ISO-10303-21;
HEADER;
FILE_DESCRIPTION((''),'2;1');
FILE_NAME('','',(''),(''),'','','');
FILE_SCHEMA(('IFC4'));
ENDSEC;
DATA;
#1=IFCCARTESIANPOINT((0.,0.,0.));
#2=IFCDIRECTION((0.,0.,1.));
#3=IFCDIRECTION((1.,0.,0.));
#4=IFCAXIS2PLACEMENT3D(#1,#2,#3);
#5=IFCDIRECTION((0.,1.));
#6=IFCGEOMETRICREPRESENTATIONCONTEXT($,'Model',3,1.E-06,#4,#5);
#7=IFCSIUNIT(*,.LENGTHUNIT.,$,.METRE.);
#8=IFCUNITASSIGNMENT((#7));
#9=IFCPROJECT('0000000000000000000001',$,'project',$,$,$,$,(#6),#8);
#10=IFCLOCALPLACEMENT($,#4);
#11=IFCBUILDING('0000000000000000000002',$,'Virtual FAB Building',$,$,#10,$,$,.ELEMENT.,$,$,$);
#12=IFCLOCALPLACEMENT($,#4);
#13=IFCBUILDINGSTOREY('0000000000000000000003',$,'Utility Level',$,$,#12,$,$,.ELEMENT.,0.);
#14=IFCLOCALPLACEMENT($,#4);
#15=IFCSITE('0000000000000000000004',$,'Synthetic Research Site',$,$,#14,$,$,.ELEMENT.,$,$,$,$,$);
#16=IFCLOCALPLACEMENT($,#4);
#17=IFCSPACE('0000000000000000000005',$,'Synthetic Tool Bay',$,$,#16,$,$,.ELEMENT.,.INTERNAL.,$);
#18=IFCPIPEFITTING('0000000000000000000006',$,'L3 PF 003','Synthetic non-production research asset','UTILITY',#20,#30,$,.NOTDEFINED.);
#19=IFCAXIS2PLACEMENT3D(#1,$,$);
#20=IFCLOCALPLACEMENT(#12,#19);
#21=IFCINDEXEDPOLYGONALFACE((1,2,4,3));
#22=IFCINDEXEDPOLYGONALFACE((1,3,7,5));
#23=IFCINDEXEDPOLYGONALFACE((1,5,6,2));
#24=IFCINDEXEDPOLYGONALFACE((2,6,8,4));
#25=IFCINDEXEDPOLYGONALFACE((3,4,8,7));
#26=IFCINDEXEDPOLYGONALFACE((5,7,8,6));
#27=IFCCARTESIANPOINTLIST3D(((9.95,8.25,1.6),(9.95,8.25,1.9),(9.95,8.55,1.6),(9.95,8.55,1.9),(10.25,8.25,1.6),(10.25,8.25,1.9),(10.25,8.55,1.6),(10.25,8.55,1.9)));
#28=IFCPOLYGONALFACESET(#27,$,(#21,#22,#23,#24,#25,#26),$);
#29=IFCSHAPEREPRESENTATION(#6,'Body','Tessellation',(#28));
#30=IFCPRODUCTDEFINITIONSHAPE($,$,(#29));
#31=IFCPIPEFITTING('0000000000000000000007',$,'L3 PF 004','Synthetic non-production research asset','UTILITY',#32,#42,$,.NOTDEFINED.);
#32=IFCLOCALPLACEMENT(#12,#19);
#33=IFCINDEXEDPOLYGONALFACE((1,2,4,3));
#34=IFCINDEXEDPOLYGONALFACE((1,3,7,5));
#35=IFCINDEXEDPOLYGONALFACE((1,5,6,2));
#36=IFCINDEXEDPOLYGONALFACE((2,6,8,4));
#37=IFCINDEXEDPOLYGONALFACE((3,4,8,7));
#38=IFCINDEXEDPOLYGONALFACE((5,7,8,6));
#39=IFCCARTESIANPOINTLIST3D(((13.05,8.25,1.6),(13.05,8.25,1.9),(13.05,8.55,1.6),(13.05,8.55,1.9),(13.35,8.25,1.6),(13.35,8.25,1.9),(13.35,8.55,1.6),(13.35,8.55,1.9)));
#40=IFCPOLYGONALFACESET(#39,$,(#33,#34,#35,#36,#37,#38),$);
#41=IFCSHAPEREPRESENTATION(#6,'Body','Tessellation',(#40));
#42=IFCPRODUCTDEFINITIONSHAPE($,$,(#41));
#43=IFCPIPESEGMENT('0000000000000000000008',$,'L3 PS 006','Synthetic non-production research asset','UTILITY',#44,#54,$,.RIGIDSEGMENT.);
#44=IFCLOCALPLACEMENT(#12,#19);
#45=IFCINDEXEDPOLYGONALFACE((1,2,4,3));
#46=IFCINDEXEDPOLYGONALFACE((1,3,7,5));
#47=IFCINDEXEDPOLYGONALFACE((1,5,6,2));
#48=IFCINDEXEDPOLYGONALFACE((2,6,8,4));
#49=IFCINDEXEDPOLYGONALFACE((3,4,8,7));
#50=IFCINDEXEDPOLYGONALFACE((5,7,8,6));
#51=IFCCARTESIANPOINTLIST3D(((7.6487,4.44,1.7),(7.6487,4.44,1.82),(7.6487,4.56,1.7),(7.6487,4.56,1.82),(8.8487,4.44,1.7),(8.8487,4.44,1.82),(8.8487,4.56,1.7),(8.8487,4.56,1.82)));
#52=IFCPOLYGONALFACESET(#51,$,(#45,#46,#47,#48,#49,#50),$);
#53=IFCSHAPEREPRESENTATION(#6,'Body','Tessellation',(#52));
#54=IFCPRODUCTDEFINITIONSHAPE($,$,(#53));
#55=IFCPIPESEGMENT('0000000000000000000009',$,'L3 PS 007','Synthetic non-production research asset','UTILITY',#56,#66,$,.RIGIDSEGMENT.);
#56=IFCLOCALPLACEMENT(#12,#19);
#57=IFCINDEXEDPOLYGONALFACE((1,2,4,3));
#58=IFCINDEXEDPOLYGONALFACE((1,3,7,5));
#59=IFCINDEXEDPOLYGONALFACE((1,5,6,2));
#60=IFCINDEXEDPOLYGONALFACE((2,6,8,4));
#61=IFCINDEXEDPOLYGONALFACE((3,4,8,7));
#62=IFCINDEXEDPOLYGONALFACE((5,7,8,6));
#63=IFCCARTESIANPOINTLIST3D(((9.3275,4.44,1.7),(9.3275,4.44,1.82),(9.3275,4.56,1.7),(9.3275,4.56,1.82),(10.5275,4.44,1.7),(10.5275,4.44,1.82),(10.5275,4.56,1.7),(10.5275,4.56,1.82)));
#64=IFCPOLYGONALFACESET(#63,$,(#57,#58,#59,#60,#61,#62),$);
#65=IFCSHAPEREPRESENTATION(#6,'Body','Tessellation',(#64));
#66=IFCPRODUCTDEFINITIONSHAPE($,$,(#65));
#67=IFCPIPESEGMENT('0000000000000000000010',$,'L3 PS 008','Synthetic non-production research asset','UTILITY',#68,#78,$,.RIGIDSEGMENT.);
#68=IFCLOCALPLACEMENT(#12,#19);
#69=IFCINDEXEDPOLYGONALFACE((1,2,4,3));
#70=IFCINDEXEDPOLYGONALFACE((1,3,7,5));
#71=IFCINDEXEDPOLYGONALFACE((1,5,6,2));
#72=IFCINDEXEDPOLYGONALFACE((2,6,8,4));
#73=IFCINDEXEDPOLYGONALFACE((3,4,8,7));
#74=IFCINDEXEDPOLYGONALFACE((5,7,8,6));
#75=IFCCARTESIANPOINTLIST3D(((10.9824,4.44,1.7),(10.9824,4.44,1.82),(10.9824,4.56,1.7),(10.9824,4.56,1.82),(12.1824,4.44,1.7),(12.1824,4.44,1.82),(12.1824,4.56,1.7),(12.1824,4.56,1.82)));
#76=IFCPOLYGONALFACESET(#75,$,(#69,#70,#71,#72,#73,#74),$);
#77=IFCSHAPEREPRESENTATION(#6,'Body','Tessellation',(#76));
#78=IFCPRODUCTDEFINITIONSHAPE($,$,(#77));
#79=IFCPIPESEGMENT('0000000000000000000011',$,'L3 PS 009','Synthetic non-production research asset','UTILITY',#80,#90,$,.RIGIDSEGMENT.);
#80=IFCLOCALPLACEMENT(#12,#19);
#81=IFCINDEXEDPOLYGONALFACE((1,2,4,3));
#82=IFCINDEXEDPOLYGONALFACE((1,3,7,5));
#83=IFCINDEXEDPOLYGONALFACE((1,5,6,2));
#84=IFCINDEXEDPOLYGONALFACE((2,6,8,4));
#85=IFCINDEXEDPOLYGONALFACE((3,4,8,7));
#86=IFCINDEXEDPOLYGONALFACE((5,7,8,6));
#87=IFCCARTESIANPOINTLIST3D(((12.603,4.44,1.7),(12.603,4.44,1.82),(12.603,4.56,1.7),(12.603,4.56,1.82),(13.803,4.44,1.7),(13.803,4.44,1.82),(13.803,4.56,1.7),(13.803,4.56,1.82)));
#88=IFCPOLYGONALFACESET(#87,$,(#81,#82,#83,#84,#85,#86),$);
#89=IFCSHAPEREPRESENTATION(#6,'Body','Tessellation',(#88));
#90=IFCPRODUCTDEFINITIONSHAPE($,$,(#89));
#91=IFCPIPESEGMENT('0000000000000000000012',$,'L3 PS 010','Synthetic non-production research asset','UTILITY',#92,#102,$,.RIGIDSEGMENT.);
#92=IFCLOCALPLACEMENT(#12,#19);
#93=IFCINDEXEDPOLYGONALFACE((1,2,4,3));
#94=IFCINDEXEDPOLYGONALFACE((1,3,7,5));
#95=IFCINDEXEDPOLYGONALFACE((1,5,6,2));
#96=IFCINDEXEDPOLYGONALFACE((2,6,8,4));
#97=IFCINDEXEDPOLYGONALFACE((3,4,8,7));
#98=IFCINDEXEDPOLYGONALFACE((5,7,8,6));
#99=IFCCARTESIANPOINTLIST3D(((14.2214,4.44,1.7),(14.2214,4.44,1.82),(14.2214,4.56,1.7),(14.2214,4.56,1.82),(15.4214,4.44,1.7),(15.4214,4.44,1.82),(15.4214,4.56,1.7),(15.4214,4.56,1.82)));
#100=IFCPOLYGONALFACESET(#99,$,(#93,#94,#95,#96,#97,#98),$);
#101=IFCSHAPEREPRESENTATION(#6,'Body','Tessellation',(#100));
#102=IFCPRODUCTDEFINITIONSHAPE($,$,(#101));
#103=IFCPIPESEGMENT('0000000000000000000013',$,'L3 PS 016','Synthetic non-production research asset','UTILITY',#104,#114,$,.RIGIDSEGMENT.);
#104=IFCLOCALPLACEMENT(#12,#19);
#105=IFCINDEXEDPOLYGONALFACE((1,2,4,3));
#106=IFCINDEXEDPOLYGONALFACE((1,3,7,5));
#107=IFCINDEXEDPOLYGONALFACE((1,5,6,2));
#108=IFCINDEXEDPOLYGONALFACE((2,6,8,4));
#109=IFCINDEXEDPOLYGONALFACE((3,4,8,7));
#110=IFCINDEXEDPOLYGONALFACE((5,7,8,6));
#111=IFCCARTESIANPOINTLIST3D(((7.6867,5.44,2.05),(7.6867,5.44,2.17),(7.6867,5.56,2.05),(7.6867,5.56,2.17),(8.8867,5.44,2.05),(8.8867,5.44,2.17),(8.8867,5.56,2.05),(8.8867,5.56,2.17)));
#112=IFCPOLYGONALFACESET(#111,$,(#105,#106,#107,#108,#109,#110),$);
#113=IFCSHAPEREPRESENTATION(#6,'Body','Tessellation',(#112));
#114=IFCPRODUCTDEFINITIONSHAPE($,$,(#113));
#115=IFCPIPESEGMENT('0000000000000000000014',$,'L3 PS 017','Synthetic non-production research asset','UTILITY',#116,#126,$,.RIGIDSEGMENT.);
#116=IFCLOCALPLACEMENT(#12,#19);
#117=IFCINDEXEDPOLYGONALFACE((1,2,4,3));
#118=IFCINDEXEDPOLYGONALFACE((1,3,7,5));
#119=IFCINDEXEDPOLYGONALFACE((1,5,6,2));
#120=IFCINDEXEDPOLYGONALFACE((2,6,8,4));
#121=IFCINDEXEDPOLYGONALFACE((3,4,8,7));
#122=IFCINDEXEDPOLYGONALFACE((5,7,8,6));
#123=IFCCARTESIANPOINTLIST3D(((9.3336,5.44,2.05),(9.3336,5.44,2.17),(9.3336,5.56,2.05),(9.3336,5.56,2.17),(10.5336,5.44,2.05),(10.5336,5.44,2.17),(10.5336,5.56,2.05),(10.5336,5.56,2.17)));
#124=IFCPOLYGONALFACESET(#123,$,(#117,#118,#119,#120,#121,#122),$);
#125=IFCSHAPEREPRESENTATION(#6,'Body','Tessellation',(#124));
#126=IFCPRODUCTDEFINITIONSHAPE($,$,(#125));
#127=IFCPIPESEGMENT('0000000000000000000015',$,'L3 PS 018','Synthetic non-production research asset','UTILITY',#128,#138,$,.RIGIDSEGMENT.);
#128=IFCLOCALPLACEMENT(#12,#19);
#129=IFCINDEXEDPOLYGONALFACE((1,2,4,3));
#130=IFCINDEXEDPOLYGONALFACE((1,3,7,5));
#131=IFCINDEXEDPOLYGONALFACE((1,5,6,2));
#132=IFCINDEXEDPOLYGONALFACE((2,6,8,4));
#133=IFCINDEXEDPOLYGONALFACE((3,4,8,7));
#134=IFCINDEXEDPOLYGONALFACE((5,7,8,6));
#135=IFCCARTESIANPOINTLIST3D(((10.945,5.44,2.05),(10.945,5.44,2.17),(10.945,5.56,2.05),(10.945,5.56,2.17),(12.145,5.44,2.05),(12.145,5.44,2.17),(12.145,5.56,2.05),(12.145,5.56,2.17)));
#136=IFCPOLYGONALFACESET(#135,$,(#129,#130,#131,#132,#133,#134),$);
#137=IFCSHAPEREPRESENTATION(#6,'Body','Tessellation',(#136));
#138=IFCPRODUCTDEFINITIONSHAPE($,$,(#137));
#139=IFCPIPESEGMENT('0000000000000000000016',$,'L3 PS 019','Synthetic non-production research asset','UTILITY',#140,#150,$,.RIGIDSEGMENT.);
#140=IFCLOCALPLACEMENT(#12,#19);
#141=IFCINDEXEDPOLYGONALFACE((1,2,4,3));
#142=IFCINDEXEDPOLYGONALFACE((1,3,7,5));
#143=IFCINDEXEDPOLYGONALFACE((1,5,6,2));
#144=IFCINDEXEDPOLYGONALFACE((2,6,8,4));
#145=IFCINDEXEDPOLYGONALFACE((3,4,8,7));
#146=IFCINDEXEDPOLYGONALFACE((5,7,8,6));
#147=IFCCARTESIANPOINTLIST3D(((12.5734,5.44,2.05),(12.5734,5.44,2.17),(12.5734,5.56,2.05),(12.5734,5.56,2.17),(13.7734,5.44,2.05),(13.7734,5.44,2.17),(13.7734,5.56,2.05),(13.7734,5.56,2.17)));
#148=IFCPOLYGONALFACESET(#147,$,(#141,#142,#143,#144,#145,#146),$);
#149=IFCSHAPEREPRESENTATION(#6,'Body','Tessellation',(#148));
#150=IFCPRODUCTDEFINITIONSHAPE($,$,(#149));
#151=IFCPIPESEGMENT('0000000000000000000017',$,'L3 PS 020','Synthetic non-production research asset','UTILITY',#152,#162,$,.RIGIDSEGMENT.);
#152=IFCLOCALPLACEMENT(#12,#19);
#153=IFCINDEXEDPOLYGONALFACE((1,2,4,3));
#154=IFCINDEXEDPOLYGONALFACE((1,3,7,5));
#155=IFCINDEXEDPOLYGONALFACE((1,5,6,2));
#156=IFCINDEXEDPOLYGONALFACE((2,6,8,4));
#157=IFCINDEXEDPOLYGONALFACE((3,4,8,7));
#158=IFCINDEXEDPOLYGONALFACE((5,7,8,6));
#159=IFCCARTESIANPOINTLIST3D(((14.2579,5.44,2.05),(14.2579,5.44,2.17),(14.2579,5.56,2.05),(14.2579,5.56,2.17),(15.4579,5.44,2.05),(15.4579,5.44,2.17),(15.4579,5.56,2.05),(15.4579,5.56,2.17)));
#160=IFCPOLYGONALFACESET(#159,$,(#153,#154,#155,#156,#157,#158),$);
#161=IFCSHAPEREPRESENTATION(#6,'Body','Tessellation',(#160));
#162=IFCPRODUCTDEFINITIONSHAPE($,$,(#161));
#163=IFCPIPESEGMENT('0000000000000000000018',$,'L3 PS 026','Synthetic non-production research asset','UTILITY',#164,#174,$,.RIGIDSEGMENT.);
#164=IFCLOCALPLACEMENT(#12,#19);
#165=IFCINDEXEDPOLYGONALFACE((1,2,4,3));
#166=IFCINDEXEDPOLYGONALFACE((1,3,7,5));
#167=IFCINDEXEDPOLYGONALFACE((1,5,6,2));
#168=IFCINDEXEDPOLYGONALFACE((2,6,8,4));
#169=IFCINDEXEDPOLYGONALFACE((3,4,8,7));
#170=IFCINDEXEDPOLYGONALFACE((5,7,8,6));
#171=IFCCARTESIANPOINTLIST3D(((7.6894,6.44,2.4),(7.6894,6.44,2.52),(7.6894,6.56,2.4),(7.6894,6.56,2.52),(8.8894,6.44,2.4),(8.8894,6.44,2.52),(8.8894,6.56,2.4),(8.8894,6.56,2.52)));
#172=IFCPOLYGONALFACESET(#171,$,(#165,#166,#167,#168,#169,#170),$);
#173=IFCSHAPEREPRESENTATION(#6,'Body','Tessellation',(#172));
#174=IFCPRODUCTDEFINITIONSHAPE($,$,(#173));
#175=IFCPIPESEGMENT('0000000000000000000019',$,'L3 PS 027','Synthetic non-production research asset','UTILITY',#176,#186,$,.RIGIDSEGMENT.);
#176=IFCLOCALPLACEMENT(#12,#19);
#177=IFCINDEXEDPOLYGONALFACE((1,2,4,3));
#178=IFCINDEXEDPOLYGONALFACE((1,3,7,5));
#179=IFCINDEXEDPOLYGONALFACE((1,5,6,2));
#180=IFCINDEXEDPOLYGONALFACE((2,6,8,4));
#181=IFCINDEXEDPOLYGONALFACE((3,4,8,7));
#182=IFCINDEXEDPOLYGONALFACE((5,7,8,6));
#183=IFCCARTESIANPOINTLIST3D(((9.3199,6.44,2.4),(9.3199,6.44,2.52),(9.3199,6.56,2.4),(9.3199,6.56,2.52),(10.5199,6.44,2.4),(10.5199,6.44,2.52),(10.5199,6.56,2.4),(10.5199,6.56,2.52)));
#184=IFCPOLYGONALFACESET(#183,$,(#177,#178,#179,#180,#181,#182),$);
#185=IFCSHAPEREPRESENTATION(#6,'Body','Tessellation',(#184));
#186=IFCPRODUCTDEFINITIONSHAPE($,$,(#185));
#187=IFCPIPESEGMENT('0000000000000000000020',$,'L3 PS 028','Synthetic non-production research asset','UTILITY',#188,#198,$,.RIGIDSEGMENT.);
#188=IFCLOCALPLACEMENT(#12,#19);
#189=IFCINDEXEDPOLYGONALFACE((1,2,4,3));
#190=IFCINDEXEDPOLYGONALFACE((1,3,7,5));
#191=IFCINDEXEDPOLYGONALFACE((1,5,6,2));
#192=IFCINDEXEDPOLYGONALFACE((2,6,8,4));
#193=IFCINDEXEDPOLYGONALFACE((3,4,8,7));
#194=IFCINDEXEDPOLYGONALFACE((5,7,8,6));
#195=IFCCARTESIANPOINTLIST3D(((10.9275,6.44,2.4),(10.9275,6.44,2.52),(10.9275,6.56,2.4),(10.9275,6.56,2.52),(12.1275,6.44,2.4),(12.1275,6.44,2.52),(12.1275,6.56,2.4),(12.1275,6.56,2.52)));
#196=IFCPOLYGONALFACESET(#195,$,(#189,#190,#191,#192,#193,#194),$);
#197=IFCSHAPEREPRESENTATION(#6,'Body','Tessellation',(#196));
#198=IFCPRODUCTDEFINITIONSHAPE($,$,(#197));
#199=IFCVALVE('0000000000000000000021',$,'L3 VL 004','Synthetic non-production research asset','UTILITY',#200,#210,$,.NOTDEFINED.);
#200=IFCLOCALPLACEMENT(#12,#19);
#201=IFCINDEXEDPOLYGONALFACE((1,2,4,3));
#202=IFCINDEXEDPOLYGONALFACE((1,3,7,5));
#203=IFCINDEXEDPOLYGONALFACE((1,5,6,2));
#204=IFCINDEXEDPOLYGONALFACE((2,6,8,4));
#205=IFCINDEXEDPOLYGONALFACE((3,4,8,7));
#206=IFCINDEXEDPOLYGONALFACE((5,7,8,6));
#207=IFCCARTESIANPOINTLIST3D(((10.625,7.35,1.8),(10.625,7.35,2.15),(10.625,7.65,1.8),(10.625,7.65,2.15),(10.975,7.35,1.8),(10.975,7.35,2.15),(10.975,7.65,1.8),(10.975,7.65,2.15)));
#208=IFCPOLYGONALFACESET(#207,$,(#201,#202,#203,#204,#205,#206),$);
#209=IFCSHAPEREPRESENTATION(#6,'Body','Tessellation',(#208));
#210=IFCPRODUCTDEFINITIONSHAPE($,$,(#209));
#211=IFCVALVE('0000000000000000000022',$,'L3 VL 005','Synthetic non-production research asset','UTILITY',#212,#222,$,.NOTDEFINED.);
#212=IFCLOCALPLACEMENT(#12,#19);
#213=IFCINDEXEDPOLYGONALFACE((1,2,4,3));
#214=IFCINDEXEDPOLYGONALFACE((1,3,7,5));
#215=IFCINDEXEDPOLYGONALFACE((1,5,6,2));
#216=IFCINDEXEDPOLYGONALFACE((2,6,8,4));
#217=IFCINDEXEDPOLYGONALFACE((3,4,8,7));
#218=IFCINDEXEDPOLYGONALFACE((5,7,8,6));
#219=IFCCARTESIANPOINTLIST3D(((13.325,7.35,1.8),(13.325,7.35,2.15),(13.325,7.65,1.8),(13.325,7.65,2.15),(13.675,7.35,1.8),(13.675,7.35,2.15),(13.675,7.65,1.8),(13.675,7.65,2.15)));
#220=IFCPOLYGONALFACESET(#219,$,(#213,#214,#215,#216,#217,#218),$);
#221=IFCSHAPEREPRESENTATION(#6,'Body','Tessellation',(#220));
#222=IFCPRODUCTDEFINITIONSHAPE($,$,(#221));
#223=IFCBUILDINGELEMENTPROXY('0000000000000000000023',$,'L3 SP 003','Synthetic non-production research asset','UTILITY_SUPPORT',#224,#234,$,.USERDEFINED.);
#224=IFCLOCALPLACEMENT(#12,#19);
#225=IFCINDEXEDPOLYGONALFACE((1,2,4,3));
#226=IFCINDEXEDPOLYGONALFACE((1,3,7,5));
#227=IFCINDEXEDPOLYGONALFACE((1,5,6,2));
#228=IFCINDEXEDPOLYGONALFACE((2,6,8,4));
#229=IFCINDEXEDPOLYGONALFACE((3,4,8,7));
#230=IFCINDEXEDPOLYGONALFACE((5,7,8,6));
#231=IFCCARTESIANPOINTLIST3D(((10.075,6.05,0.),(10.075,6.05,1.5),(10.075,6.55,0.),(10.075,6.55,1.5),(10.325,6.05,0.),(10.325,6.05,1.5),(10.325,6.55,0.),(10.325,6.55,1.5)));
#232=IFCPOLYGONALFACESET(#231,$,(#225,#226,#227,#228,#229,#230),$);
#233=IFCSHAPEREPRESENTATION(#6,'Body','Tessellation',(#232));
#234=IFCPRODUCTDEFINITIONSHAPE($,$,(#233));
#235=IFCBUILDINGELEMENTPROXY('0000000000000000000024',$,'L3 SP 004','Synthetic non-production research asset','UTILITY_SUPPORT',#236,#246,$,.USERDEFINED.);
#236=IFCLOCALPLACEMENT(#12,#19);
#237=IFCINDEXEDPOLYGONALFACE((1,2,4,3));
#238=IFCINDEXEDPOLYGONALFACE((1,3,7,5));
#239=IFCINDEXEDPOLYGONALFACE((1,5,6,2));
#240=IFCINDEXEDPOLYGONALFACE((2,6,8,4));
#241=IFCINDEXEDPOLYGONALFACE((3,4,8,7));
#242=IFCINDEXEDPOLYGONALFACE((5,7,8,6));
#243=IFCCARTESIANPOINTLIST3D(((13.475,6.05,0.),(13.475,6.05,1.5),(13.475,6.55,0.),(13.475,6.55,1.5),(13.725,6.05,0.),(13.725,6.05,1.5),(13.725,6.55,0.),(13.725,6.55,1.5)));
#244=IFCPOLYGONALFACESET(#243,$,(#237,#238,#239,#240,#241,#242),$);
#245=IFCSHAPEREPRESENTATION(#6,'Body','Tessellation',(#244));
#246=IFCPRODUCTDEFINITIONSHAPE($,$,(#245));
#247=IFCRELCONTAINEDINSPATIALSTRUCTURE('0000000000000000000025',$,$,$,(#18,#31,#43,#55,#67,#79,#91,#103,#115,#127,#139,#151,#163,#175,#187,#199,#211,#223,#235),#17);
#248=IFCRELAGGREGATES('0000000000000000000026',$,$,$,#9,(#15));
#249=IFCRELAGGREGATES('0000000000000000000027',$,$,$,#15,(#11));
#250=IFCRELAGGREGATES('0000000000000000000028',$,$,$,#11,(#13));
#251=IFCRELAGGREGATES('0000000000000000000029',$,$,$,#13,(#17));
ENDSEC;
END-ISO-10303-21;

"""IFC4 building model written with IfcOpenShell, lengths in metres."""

from ifc_helpers import new_model, si_unit, direction, frame, origin_with_axes, origin_2d_with_axis, place, context, project, spatial, rectangle, extrude, element, save


model = new_model("IFC4")

# Units and contexts
model_context = context("Model", 3, precision=1e-06, world=origin_with_axes(), true_north=direction((0.0, 1.0)))
ifc_project = project(units=[si_unit("LENGTHUNIT", "METRE")], contexts=[model_context])

# Site, building, storey, space
site_placement = place(None, origin_with_axes())
site = spatial("IfcSite", under=ifc_project, at=site_placement, Name="Synthetic Research Site", CompositionType="ELEMENT")
building_placement = place(None, origin_with_axes())
building = spatial("IfcBuilding", under=site, at=building_placement, Name="Virtual FAB Building", CompositionType="ELEMENT")
storey_placement = place(None, origin_with_axes())
storey = spatial("IfcBuildingStorey", under=building, at=storey_placement, Name="Utility Level", CompositionType="ELEMENT", Elevation=0.0)
space_placement = place(None, origin_with_axes())
space = spatial("IfcSpace", under=storey, at=space_placement, Name="Synthetic Tool Bay", CompositionType="ELEMENT", PredefinedType="INTERNAL")

# Pipe fittings
for number, where, z_axis, x_axis, name in (
    (1, (10.1, 8.4, 1.6), (0.0, 0.0, 1.0), (1.0, 0.0, 0.0), "L3 PF 003"),
    (2, (13.2, 8.4, 1.6), (0.0, 0.0, 1.0), (1.0, 0.0, 0.0), "L3 PF 004"),
):
    element("IfcPipeFitting", number, at=place(None, frame(where, z_axis=z_axis, x_axis=x_axis)), inside=space, Name=name, Description="Synthetic non-production research asset", ObjectType="UTILITY", PredefinedType="NOTDEFINED", context=model_context, shape_type="SweptSolid", body=[
        extrude(rectangle(XDim=0.3, YDim=0.3, at=origin_2d_with_axis()), origin_with_axes(), (0.0, 0.0, 1.0), 0.3),
    ])

# Pipe segments
for number, where, z_axis, x_axis, name in (
    (3, (8.2487, 4.5, 1.7), (0.0, 0.0, 1.0), (1.0, 0.0, 0.0), "L3 PS 006"),
    (4, (9.9275, 4.5, 1.7), (0.0, 0.0, 1.0), (1.0, 0.0, 0.0), "L3 PS 007"),
    (5, (11.5824, 4.5, 1.7), (0.0, 0.0, 1.0), (1.0, 0.0, 0.0), "L3 PS 008"),
    (6, (13.203, 4.5, 1.7), (0.0, 0.0, 1.0), (1.0, 0.0, 0.0), "L3 PS 009"),
    (7, (14.8214, 4.5, 1.7), (0.0, 0.0, 1.0), (1.0, 0.0, 0.0), "L3 PS 010"),
    (8, (8.2867, 5.5, 2.05), (0.0, 0.0, 1.0), (1.0, 0.0, 0.0), "L3 PS 016"),
    (9, (9.9336, 5.5, 2.05), (0.0, 0.0, 1.0), (1.0, 0.0, 0.0), "L3 PS 017"),
    (10, (11.545, 5.5, 2.05), (0.0, 0.0, 1.0), (1.0, 0.0, 0.0), "L3 PS 018"),
    (11, (13.1734, 5.5, 2.05), (0.0, 0.0, 1.0), (1.0, 0.0, 0.0), "L3 PS 019"),
    (12, (14.8579, 5.5, 2.05), (0.0, 0.0, 1.0), (1.0, 0.0, 0.0), "L3 PS 020"),
    (13, (8.2894, 6.5, 2.4), (0.0, 0.0, 1.0), (1.0, 0.0, 0.0), "L3 PS 026"),
    (14, (9.9199, 6.5, 2.4), (0.0, 0.0, 1.0), (1.0, 0.0, 0.0), "L3 PS 027"),
    (15, (11.5275, 6.5, 2.4), (0.0, 0.0, 1.0), (1.0, 0.0, 0.0), "L3 PS 028"),
):
    element("IfcPipeSegment", number, at=place(None, frame(where, z_axis=z_axis, x_axis=x_axis)), inside=space, Name=name, Description="Synthetic non-production research asset", ObjectType="UTILITY", PredefinedType="RIGIDSEGMENT", context=model_context, shape_type="SweptSolid", body=[
        extrude(rectangle(XDim=1.2, YDim=0.12, at=origin_2d_with_axis()), origin_with_axes(), (0.0, 0.0, 1.0), 0.12),
    ])

# Valves
for number, where, z_axis, x_axis, name in (
    (16, (10.8, 7.5, 1.8), (0.0, 0.0, 1.0), (1.0, 0.0, 0.0), "L3 VL 004"),
    (17, (13.5, 7.5, 1.8), (0.0, 0.0, 1.0), (1.0, 0.0, 0.0), "L3 VL 005"),
):
    element("IfcValve", number, at=place(None, frame(where, z_axis=z_axis, x_axis=x_axis)), inside=space, Name=name, Description="Synthetic non-production research asset", ObjectType="UTILITY", PredefinedType="NOTDEFINED", context=model_context, shape_type="SweptSolid", body=[
        extrude(rectangle(XDim=0.35, YDim=0.3, at=origin_2d_with_axis()), origin_with_axes(), (0.0, 0.0, 1.0), 0.35),
    ])

# Building element proxies
for number, where, z_axis, x_axis, name in (
    (18, (10.2, 6.3, 0.0), (0.0, 0.0, 1.0), (1.0, 0.0, 0.0), "L3 SP 003"),
    (19, (13.6, 6.3, 0.0), (0.0, 0.0, 1.0), (1.0, 0.0, 0.0), "L3 SP 004"),
):
    element("IfcBuildingElementProxy", number, at=place(None, frame(where, z_axis=z_axis, x_axis=x_axis)), inside=space, Name=name, Description="Synthetic non-production research asset", ObjectType="UTILITY_SUPPORT", PredefinedType="USERDEFINED", context=model_context, shape_type="SweptSolid", body=[
        extrude(rectangle(XDim=0.25, YDim=0.5, at=origin_2d_with_axis()), origin_with_axes(), (0.0, 0.0, 1.0), 1.5),
    ])

save(model, "model.ifc")
